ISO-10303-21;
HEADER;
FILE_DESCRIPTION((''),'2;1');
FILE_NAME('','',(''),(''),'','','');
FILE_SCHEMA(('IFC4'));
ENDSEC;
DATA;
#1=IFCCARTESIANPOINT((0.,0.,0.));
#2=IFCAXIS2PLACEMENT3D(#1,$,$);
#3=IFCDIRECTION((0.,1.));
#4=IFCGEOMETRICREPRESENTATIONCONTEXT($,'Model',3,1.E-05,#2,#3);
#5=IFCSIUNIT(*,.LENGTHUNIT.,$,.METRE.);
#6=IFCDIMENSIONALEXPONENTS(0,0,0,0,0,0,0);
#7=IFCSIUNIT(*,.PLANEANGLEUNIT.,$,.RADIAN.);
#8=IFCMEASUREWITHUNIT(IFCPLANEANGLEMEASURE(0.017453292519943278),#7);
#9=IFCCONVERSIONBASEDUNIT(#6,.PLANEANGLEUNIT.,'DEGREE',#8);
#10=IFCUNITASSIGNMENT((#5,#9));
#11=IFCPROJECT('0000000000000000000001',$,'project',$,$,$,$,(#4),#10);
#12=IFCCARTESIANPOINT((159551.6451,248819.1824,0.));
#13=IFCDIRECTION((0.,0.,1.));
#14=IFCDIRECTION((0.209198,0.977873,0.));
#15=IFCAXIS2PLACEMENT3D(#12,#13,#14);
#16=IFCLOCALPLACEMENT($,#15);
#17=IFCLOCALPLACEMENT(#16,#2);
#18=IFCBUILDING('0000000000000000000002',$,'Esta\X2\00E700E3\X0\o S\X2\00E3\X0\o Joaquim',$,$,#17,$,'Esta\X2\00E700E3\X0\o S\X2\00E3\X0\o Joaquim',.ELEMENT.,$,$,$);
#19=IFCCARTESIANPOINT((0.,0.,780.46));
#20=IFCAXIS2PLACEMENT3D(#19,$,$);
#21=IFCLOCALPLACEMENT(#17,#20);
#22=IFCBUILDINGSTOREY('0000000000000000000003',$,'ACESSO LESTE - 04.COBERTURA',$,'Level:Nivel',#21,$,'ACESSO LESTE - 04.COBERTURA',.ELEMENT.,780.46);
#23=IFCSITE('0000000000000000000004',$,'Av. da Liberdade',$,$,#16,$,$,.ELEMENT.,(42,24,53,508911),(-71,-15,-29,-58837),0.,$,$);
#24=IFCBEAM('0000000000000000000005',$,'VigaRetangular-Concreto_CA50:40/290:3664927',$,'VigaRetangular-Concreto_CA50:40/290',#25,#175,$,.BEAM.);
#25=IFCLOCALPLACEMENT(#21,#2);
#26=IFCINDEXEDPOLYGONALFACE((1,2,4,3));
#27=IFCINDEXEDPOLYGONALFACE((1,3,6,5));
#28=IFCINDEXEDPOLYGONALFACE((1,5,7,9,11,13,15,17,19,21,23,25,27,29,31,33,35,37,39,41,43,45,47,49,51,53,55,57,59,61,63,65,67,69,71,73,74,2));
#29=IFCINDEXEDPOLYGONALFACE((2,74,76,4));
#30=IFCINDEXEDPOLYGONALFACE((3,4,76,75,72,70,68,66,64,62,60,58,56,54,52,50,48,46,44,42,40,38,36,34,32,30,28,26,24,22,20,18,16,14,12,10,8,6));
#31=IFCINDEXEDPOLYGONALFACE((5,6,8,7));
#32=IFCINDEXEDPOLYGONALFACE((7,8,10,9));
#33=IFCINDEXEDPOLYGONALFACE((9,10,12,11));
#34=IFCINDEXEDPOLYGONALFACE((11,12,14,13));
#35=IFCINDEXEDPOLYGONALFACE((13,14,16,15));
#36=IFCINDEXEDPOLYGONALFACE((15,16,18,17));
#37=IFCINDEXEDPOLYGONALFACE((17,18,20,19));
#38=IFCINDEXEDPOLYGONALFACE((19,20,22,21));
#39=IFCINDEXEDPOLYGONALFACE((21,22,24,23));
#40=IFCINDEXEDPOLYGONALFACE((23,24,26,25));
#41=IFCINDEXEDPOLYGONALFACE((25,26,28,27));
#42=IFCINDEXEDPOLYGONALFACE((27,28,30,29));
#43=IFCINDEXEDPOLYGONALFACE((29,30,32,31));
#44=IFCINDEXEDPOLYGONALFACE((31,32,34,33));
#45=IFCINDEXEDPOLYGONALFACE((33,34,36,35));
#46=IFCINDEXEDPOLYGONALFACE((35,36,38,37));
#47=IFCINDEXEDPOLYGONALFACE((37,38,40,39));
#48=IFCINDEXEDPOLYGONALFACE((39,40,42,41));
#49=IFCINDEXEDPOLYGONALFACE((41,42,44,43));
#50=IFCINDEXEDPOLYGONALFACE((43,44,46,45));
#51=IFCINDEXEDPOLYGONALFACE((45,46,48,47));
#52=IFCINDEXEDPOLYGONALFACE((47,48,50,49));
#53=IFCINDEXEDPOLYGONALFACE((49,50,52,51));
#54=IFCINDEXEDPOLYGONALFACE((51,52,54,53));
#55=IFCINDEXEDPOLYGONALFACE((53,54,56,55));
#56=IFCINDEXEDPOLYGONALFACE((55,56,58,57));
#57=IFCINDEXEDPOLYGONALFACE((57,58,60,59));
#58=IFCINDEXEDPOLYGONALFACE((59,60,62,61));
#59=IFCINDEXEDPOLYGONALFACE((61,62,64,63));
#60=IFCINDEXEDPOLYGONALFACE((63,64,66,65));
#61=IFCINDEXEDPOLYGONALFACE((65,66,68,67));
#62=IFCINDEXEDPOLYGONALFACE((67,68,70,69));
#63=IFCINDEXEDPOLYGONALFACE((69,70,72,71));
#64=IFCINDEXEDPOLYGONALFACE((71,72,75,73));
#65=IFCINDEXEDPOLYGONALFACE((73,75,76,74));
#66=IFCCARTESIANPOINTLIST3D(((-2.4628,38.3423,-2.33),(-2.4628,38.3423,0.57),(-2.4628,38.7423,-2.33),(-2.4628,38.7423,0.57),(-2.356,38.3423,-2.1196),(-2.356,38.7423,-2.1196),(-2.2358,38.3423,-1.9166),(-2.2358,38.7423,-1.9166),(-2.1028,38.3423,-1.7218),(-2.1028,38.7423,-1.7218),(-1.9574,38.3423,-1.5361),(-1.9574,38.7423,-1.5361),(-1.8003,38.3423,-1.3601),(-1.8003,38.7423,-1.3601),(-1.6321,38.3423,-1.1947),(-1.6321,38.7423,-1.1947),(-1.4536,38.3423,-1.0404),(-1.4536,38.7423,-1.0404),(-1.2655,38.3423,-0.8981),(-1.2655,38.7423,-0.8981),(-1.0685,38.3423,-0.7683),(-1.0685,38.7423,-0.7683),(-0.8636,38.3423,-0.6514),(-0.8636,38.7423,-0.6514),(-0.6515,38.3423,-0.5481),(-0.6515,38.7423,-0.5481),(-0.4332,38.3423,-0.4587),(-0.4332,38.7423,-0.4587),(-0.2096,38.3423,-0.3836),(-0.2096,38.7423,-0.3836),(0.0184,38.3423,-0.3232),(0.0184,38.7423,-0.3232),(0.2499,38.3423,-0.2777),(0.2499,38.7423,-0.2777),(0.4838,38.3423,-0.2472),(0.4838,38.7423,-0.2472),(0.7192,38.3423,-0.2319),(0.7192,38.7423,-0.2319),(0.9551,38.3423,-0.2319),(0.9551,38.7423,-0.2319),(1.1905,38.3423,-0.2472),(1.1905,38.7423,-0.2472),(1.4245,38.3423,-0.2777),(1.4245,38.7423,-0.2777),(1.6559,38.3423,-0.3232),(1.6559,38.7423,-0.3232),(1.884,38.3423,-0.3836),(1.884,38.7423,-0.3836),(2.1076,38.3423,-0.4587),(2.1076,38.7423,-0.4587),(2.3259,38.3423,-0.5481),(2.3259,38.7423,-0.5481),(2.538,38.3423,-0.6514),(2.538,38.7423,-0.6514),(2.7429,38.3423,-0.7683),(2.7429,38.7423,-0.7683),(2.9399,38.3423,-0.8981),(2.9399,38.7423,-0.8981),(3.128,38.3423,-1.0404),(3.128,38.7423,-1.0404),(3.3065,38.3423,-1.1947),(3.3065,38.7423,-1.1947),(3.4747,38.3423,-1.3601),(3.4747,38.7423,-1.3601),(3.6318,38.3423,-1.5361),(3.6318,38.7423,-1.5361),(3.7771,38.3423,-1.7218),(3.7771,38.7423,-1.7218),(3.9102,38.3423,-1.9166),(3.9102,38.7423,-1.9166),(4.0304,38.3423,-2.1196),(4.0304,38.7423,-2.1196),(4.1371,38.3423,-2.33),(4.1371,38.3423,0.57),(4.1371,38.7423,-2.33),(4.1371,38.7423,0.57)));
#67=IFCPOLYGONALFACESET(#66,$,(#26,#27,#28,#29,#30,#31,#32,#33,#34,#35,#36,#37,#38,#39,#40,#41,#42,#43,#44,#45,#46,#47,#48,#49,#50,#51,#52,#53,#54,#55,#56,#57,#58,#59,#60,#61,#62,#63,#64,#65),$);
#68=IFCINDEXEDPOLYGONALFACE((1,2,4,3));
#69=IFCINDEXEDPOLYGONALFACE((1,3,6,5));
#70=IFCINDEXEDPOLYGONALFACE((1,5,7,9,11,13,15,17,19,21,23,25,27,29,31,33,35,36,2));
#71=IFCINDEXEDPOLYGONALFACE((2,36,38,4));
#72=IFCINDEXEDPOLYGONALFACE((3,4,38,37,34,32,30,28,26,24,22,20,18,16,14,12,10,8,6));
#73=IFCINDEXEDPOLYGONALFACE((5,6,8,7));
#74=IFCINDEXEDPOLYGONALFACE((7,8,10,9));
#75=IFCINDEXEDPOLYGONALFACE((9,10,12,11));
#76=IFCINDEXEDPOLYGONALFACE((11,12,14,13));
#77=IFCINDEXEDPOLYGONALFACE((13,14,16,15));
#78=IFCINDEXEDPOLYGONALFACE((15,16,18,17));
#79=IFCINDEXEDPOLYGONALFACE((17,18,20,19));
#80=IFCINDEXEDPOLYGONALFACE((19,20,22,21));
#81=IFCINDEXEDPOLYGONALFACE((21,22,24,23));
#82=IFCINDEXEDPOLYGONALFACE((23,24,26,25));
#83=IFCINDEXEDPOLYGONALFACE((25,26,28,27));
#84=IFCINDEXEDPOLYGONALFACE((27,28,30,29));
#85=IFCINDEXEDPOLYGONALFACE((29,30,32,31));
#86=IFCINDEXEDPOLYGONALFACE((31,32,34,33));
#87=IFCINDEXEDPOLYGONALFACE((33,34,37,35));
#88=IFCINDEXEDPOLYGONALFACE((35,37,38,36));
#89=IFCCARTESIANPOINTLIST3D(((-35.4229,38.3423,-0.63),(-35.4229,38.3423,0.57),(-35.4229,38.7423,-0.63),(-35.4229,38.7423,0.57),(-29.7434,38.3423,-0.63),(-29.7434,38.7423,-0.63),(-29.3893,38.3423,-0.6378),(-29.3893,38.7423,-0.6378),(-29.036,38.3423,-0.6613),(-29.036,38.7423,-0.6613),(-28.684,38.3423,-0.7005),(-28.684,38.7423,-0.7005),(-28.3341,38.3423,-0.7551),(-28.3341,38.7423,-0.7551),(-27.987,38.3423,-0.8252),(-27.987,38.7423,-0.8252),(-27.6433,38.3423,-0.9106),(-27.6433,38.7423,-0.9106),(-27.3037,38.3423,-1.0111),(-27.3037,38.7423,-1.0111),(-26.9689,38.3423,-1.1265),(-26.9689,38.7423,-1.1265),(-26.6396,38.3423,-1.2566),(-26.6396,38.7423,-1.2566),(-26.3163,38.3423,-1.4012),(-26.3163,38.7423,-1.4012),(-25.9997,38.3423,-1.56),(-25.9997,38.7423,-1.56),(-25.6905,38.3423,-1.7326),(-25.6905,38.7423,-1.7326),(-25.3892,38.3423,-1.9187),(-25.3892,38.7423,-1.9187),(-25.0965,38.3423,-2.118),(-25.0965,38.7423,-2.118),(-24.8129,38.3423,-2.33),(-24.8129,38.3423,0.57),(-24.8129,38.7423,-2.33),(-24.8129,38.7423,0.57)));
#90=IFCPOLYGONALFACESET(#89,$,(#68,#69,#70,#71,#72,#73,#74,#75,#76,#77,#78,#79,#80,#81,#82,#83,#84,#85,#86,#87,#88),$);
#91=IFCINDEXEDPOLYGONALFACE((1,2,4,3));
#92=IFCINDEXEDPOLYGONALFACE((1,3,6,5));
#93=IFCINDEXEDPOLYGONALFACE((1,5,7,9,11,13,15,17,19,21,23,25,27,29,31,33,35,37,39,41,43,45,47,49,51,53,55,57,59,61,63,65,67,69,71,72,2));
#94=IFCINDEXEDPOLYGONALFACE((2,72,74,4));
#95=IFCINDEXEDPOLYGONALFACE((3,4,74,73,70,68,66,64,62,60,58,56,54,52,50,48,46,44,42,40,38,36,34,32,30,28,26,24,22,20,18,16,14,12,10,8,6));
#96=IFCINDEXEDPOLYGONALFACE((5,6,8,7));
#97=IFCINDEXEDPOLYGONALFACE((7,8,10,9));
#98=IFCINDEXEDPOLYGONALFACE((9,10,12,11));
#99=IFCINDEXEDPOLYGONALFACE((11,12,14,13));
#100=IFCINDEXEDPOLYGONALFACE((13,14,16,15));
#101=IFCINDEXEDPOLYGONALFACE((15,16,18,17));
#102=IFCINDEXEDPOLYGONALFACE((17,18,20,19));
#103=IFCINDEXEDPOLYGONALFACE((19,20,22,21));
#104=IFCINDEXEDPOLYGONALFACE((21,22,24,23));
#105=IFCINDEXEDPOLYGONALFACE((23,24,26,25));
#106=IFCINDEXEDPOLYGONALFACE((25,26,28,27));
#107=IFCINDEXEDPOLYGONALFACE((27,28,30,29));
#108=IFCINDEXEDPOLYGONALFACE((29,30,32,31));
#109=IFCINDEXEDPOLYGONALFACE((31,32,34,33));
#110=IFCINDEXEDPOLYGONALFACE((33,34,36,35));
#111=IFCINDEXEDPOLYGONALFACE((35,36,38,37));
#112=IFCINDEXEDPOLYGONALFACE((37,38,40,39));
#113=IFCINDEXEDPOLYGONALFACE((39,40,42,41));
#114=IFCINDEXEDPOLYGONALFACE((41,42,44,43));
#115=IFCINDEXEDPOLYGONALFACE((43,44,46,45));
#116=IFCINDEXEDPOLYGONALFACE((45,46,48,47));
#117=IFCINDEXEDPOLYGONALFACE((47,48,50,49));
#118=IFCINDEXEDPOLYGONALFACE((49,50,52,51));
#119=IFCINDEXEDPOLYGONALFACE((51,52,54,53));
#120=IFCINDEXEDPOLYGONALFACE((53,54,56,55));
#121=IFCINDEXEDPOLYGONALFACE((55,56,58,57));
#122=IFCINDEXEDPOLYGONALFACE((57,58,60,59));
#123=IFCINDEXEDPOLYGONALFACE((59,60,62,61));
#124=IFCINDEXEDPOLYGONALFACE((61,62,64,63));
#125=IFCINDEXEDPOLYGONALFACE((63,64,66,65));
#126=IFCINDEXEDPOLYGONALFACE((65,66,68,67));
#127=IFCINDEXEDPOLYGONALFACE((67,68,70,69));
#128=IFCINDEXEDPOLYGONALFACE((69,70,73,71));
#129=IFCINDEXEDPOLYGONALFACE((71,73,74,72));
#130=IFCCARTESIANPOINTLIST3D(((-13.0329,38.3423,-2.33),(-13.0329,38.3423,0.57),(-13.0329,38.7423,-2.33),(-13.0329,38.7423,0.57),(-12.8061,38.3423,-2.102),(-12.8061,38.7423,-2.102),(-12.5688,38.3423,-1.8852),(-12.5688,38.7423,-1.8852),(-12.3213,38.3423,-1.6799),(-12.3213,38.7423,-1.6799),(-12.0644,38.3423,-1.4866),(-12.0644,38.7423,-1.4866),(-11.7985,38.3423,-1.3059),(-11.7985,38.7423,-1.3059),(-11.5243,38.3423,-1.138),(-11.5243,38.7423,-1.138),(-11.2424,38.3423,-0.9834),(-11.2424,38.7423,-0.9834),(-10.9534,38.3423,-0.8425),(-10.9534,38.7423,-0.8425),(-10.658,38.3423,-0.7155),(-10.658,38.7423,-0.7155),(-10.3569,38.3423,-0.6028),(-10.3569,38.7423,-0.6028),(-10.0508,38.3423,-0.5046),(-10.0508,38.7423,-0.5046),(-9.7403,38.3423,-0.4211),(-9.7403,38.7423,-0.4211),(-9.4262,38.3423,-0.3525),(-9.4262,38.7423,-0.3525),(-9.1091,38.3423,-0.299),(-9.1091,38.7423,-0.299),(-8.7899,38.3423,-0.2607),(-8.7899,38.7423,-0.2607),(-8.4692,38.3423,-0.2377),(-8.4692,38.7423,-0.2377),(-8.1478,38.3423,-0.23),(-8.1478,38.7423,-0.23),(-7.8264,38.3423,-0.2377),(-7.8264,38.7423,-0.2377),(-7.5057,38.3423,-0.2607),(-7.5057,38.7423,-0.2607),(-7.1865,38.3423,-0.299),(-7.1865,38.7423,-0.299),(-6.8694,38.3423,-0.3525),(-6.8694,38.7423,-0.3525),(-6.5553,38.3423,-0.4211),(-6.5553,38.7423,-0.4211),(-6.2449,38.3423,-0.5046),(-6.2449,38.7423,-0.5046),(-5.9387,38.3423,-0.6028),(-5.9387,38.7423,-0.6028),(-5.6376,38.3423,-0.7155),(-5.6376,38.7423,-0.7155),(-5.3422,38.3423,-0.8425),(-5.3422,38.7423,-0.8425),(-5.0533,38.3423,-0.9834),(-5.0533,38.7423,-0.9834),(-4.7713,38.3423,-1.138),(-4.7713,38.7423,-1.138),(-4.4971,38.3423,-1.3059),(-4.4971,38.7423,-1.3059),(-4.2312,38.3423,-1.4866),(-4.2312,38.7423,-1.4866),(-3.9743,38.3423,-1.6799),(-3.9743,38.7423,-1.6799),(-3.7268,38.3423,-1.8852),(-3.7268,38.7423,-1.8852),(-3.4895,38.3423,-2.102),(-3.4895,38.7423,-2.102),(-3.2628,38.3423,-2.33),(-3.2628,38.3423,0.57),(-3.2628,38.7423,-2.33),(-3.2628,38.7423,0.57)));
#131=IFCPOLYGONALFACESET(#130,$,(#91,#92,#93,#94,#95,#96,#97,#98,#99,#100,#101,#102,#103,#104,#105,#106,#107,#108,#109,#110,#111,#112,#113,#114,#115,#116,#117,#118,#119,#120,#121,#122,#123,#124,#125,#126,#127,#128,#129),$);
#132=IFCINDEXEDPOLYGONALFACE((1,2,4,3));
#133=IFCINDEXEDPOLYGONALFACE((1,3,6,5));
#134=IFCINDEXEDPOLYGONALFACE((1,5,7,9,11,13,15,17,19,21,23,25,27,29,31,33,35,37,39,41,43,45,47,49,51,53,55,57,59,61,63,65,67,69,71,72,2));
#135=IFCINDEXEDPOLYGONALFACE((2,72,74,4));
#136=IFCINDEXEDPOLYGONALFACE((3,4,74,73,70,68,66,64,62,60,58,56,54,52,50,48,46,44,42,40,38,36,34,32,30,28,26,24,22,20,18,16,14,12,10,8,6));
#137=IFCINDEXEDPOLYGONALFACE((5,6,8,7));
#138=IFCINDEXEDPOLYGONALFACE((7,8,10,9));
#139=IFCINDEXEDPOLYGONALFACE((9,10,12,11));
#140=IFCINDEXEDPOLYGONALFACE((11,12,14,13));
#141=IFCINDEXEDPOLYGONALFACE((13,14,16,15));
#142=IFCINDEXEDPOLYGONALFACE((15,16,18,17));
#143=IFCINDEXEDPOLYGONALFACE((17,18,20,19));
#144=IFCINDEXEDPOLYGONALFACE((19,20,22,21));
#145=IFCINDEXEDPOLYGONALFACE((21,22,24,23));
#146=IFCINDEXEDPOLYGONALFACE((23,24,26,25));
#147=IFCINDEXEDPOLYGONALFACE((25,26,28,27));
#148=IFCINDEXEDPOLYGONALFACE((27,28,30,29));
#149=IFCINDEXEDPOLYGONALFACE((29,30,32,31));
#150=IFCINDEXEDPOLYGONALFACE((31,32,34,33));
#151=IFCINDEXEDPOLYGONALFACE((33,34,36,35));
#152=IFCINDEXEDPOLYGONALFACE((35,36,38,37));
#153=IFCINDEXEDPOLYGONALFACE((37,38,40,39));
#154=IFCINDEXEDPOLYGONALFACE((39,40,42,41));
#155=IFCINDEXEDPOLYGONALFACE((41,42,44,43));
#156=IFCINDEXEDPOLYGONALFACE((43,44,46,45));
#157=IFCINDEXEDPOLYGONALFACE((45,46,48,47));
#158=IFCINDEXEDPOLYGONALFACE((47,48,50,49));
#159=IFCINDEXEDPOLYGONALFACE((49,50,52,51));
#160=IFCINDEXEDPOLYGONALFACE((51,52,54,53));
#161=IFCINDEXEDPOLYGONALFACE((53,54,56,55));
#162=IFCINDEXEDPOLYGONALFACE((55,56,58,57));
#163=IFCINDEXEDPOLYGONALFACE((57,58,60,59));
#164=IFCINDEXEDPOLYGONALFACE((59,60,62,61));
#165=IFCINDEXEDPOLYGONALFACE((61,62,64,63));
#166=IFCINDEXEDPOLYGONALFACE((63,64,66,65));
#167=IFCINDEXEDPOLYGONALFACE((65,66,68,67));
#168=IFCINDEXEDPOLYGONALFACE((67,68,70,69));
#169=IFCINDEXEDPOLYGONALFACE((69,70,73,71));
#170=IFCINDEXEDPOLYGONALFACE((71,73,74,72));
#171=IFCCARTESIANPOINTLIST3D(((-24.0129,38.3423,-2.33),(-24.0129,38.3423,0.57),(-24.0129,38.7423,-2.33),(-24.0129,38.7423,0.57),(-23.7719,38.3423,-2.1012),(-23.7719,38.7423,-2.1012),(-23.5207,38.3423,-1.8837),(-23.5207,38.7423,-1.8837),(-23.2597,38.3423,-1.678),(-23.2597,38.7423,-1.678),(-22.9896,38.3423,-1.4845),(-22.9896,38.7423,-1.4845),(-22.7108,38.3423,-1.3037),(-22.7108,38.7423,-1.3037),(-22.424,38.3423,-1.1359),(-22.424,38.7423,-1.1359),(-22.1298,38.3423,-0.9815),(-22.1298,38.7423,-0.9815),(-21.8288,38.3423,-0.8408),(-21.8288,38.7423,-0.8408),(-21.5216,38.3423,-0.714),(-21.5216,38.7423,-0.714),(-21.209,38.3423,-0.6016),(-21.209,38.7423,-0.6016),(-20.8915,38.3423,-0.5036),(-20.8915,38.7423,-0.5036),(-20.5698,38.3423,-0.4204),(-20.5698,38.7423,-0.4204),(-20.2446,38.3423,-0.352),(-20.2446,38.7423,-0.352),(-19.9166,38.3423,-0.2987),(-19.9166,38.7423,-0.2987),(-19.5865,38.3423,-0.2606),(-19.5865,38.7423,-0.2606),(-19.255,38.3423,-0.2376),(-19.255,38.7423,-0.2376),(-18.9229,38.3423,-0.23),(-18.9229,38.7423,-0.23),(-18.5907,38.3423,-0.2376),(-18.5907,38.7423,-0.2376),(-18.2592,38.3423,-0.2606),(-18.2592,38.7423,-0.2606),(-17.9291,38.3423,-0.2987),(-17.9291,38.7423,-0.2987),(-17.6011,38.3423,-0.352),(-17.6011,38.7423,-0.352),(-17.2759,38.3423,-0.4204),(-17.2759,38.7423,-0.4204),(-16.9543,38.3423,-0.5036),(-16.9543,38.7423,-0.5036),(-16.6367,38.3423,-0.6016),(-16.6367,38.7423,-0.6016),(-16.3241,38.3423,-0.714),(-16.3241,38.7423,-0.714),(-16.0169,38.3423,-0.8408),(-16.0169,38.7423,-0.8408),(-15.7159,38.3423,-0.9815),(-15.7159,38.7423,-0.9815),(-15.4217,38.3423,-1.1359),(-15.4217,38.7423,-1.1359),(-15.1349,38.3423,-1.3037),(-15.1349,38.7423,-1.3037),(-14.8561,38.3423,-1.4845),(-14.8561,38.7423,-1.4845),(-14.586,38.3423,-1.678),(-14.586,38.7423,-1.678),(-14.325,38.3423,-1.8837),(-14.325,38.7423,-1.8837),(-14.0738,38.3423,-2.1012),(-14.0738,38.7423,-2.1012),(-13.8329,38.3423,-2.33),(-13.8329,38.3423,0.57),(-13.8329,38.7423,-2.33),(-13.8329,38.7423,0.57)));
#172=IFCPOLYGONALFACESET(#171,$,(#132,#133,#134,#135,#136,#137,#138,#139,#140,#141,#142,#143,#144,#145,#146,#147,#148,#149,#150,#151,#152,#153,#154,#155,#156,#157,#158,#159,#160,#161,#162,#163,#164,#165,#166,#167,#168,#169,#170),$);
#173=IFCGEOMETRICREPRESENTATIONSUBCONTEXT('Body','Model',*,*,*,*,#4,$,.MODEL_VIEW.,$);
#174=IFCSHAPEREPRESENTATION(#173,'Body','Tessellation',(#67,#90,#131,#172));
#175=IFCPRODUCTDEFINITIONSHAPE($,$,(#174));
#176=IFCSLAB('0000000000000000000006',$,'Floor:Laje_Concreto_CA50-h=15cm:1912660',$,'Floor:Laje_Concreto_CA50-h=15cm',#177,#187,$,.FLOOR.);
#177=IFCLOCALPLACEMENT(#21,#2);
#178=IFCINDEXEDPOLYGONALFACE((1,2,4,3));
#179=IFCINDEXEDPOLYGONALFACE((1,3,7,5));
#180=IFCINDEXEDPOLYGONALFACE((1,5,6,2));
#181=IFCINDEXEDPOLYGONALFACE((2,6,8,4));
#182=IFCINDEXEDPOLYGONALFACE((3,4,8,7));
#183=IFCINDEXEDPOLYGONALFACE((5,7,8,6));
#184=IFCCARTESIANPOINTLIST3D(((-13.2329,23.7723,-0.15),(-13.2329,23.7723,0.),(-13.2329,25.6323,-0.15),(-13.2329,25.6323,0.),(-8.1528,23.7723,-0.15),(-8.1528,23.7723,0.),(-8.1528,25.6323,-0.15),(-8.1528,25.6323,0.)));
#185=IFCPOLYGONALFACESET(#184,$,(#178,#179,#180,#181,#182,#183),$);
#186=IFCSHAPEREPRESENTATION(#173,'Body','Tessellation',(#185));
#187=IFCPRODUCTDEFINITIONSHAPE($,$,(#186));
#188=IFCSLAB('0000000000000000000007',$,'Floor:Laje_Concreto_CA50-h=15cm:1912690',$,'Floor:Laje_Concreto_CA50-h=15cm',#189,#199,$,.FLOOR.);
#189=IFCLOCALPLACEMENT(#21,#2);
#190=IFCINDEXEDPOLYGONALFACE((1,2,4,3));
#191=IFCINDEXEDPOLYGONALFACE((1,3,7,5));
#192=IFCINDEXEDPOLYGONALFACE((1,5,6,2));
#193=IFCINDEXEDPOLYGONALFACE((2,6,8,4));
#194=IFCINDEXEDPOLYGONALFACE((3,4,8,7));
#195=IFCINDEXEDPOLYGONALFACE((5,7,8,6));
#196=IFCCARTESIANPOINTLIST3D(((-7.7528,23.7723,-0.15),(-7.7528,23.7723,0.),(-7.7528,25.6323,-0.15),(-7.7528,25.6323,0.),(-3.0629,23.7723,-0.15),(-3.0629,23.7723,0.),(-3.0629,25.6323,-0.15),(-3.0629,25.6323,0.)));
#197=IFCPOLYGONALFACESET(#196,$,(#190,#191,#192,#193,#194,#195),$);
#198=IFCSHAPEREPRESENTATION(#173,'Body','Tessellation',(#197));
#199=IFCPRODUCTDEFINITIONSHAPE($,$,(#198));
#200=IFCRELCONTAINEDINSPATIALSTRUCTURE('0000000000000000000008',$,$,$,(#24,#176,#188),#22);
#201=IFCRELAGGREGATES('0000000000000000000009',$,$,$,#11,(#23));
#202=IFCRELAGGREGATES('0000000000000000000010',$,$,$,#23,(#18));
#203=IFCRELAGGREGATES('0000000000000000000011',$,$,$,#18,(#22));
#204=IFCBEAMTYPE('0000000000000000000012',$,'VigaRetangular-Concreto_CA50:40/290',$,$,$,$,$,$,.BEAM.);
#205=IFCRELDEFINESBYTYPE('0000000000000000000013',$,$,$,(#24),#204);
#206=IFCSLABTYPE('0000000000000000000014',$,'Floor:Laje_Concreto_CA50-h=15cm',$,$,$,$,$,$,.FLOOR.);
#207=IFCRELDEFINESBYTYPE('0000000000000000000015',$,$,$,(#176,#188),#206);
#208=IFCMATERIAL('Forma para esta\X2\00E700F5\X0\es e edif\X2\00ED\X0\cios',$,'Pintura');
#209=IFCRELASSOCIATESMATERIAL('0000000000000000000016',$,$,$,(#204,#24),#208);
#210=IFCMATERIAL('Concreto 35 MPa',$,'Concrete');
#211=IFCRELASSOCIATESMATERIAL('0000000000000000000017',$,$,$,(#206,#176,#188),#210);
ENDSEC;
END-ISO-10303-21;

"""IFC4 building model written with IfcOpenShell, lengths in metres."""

from ifc_helpers import new_model, entity, si_unit, converted_unit, direction, frame, origin, place, context, subcontext, project, spatial, line, arc, indexed_curve, outline, extrude, source, transform, mapped, material, type_object, type_shapes, element, save


model = new_model("IFC4")

# Units and contexts
model_context = context("Model", 3, precision=1e-05, world=origin(), true_north=direction((0.0, 1.0)))
body_context = subcontext(model_context, "Body", "Model", "MODEL_VIEW")
ifc_project = project(units=[si_unit("LENGTHUNIT", "METRE"), converted_unit("PLANEANGLEUNIT", "DEGREE", entity("IfcPlaneAngleMeasure", 0.017453292519943278), si_unit("PLANEANGLEUNIT", "RADIAN"), dimensions=[0, 0, 0, 0, 0, 0, 0])], contexts=[model_context])

# Site, building, storey
site_placement = place(None, frame((159551.6451, 248819.1824, 0.0), z_axis=(0.0, 0.0, 1.0), x_axis=(0.209198, 0.977873, 0.0)))
site = spatial("IfcSite", under=ifc_project, at=site_placement, Name="Av. da Liberdade", CompositionType="ELEMENT", RefLatitude=(42, 24, 53, 508911), RefLongitude=(-71, -15, -29, -58837), RefElevation=0.0)
building_placement = place(site_placement, origin())
building = spatial("IfcBuilding", under=site, at=building_placement, Name="Estação São Joaquim", LongName="Estação São Joaquim", CompositionType="ELEMENT")
storey_placement = place(building_placement, frame((0.0, 0.0, 780.46)))
storey = spatial("IfcBuildingStorey", under=building, at=storey_placement, Name="ACESSO LESTE - 04.COBERTURA", ObjectType="Level:Nivel", LongName="ACESSO LESTE - 04.COBERTURA", CompositionType="ELEMENT", Elevation=780.46)

# Beam
ifc_material_1 = material(Name="Forma para estações e edifícios", Category="Pintura")
beam_type_1 = type_object("IfcBeamType", Name="VigaRetangular-Concreto_CA50:40/290", PredefinedType="BEAM", material=ifc_material_1)
shared_shape_1 = source(origin(), body_context, "Body", "SweptSolid", [
    extrude(outline(indexed_curve([(3.3, -1.45), (3.3, 1.45), (-3.3, 1.45), (-3.3, -1.45), (0.0, 0.65)], segments=[line(1, 2, 3, 4), arc(4, 5, 1)], self_intersect=False)), frame((36.26, 0.0, 1.4516), z_axis=(0.0, -1.0, 0.0), x_axis=(1.0, 0.0, 0.0)), (0.0, 0.0, -1.0), 0.4),
    extrude(outline(indexed_curve([(-0.2996, -0.14), (5.3799, -0.14), (5.3799, 1.06), (-5.2301, 1.06), (-5.2301, -1.84), (-2.9073, -0.5769)], segments=[line(1, 2, 3, 4, 5), arc(5, 6, 1)], self_intersect=False)), frame((5.3799, 0.0, 1.8416), z_axis=(0.0, 1.0, 0.0), x_axis=(-1.0, 0.0, 0.0)), (0.0, 0.0, 1.0), 0.4),
    extrude(outline(indexed_curve([(4.885, -1.45), (4.885, 1.45), (-4.885, 1.45), (-4.885, -1.45), (0.0, 0.65)], segments=[line(1, 2, 3, 4), arc(4, 5, 1)], self_intersect=False)), frame((27.275, 0.0, 1.4516), z_axis=(0.0, -1.0, 0.0), x_axis=(1.0, 0.0, 0.0)), (0.0, 0.0, -1.0), 0.4),
    extrude(outline(indexed_curve([(5.09, -1.45), (5.09, 1.45), (-5.09, 1.45), (-5.09, -1.45), (0.0, 0.65)], segments=[line(1, 2, 3, 4), arc(4, 5, 1)], self_intersect=False)), frame((16.5, 0.0, 1.4516), z_axis=(0.0, -1.0, 0.0), x_axis=(1.0, 0.0, 0.0)), (0.0, 0.0, -1.0), 0.4),
])
type_shapes(beam_type_1, [shared_shape_1])
beam_1_placement = place(storey_placement, frame((-35.4229, 38.3423, -2.3316)))
element("IfcBeam", 1, at=beam_1_placement, inside=storey, type_object=beam_type_1, material=ifc_material_1, Name="VigaRetangular-Concreto_CA50:40/290:3664927", ObjectType="VigaRetangular-Concreto_CA50:40/290", PredefinedType="BEAM", context=body_context, shape_type="MappedRepresentation", body=[
    mapped(shared_shape_1, transform((0.0, 0.0, 0.0), scale=1.0)),
])

# Slabs
ifc_material_2 = material(Name="Concreto 35 MPa", Category="Concrete")
slab_type_1 = type_object("IfcSlabType", Name="Floor:Laje_Concreto_CA50-h=15cm", PredefinedType="FLOOR", material=ifc_material_2)
slab_1_placement = place(storey_placement, origin())
element("IfcSlab", 2, at=slab_1_placement, inside=storey, type_object=slab_type_1, material=ifc_material_2, Name="Floor:Laje_Concreto_CA50-h=15cm:1912660", ObjectType="Floor:Laje_Concreto_CA50-h=15cm", PredefinedType="FLOOR", context=body_context, shape_type="SweptSolid", body=[
    extrude(outline(indexed_curve([(-0.93, -2.54), (0.93, -2.54), (0.93, 2.54), (-0.93, 2.54), (-0.93, -2.54)], self_intersect=False)), frame((-10.6929, 24.7023, 0.0), z_axis=(0.0, 0.0, -1.0), x_axis=(0.0, 1.0, 0.0)), (0.0, 0.0, 1.0), 0.15),
])
slab_2_placement = place(storey_placement, origin())
element("IfcSlab", 3, at=slab_2_placement, inside=storey, type_object=slab_type_1, material=ifc_material_2, Name="Floor:Laje_Concreto_CA50-h=15cm:1912690", ObjectType="Floor:Laje_Concreto_CA50-h=15cm", PredefinedType="FLOOR", context=body_context, shape_type="SweptSolid", body=[
    extrude(outline(indexed_curve([(-0.93, -2.345), (0.93, -2.345), (0.93, 2.345), (-0.93, 2.345), (-0.93, -2.345)], self_intersect=False)), frame((-5.4079, 24.7023, 0.0), z_axis=(0.0, 0.0, -1.0), x_axis=(0.0, 1.0, 0.0)), (0.0, 0.0, 1.0), 0.15),
])

save(model, "model.ifc")
